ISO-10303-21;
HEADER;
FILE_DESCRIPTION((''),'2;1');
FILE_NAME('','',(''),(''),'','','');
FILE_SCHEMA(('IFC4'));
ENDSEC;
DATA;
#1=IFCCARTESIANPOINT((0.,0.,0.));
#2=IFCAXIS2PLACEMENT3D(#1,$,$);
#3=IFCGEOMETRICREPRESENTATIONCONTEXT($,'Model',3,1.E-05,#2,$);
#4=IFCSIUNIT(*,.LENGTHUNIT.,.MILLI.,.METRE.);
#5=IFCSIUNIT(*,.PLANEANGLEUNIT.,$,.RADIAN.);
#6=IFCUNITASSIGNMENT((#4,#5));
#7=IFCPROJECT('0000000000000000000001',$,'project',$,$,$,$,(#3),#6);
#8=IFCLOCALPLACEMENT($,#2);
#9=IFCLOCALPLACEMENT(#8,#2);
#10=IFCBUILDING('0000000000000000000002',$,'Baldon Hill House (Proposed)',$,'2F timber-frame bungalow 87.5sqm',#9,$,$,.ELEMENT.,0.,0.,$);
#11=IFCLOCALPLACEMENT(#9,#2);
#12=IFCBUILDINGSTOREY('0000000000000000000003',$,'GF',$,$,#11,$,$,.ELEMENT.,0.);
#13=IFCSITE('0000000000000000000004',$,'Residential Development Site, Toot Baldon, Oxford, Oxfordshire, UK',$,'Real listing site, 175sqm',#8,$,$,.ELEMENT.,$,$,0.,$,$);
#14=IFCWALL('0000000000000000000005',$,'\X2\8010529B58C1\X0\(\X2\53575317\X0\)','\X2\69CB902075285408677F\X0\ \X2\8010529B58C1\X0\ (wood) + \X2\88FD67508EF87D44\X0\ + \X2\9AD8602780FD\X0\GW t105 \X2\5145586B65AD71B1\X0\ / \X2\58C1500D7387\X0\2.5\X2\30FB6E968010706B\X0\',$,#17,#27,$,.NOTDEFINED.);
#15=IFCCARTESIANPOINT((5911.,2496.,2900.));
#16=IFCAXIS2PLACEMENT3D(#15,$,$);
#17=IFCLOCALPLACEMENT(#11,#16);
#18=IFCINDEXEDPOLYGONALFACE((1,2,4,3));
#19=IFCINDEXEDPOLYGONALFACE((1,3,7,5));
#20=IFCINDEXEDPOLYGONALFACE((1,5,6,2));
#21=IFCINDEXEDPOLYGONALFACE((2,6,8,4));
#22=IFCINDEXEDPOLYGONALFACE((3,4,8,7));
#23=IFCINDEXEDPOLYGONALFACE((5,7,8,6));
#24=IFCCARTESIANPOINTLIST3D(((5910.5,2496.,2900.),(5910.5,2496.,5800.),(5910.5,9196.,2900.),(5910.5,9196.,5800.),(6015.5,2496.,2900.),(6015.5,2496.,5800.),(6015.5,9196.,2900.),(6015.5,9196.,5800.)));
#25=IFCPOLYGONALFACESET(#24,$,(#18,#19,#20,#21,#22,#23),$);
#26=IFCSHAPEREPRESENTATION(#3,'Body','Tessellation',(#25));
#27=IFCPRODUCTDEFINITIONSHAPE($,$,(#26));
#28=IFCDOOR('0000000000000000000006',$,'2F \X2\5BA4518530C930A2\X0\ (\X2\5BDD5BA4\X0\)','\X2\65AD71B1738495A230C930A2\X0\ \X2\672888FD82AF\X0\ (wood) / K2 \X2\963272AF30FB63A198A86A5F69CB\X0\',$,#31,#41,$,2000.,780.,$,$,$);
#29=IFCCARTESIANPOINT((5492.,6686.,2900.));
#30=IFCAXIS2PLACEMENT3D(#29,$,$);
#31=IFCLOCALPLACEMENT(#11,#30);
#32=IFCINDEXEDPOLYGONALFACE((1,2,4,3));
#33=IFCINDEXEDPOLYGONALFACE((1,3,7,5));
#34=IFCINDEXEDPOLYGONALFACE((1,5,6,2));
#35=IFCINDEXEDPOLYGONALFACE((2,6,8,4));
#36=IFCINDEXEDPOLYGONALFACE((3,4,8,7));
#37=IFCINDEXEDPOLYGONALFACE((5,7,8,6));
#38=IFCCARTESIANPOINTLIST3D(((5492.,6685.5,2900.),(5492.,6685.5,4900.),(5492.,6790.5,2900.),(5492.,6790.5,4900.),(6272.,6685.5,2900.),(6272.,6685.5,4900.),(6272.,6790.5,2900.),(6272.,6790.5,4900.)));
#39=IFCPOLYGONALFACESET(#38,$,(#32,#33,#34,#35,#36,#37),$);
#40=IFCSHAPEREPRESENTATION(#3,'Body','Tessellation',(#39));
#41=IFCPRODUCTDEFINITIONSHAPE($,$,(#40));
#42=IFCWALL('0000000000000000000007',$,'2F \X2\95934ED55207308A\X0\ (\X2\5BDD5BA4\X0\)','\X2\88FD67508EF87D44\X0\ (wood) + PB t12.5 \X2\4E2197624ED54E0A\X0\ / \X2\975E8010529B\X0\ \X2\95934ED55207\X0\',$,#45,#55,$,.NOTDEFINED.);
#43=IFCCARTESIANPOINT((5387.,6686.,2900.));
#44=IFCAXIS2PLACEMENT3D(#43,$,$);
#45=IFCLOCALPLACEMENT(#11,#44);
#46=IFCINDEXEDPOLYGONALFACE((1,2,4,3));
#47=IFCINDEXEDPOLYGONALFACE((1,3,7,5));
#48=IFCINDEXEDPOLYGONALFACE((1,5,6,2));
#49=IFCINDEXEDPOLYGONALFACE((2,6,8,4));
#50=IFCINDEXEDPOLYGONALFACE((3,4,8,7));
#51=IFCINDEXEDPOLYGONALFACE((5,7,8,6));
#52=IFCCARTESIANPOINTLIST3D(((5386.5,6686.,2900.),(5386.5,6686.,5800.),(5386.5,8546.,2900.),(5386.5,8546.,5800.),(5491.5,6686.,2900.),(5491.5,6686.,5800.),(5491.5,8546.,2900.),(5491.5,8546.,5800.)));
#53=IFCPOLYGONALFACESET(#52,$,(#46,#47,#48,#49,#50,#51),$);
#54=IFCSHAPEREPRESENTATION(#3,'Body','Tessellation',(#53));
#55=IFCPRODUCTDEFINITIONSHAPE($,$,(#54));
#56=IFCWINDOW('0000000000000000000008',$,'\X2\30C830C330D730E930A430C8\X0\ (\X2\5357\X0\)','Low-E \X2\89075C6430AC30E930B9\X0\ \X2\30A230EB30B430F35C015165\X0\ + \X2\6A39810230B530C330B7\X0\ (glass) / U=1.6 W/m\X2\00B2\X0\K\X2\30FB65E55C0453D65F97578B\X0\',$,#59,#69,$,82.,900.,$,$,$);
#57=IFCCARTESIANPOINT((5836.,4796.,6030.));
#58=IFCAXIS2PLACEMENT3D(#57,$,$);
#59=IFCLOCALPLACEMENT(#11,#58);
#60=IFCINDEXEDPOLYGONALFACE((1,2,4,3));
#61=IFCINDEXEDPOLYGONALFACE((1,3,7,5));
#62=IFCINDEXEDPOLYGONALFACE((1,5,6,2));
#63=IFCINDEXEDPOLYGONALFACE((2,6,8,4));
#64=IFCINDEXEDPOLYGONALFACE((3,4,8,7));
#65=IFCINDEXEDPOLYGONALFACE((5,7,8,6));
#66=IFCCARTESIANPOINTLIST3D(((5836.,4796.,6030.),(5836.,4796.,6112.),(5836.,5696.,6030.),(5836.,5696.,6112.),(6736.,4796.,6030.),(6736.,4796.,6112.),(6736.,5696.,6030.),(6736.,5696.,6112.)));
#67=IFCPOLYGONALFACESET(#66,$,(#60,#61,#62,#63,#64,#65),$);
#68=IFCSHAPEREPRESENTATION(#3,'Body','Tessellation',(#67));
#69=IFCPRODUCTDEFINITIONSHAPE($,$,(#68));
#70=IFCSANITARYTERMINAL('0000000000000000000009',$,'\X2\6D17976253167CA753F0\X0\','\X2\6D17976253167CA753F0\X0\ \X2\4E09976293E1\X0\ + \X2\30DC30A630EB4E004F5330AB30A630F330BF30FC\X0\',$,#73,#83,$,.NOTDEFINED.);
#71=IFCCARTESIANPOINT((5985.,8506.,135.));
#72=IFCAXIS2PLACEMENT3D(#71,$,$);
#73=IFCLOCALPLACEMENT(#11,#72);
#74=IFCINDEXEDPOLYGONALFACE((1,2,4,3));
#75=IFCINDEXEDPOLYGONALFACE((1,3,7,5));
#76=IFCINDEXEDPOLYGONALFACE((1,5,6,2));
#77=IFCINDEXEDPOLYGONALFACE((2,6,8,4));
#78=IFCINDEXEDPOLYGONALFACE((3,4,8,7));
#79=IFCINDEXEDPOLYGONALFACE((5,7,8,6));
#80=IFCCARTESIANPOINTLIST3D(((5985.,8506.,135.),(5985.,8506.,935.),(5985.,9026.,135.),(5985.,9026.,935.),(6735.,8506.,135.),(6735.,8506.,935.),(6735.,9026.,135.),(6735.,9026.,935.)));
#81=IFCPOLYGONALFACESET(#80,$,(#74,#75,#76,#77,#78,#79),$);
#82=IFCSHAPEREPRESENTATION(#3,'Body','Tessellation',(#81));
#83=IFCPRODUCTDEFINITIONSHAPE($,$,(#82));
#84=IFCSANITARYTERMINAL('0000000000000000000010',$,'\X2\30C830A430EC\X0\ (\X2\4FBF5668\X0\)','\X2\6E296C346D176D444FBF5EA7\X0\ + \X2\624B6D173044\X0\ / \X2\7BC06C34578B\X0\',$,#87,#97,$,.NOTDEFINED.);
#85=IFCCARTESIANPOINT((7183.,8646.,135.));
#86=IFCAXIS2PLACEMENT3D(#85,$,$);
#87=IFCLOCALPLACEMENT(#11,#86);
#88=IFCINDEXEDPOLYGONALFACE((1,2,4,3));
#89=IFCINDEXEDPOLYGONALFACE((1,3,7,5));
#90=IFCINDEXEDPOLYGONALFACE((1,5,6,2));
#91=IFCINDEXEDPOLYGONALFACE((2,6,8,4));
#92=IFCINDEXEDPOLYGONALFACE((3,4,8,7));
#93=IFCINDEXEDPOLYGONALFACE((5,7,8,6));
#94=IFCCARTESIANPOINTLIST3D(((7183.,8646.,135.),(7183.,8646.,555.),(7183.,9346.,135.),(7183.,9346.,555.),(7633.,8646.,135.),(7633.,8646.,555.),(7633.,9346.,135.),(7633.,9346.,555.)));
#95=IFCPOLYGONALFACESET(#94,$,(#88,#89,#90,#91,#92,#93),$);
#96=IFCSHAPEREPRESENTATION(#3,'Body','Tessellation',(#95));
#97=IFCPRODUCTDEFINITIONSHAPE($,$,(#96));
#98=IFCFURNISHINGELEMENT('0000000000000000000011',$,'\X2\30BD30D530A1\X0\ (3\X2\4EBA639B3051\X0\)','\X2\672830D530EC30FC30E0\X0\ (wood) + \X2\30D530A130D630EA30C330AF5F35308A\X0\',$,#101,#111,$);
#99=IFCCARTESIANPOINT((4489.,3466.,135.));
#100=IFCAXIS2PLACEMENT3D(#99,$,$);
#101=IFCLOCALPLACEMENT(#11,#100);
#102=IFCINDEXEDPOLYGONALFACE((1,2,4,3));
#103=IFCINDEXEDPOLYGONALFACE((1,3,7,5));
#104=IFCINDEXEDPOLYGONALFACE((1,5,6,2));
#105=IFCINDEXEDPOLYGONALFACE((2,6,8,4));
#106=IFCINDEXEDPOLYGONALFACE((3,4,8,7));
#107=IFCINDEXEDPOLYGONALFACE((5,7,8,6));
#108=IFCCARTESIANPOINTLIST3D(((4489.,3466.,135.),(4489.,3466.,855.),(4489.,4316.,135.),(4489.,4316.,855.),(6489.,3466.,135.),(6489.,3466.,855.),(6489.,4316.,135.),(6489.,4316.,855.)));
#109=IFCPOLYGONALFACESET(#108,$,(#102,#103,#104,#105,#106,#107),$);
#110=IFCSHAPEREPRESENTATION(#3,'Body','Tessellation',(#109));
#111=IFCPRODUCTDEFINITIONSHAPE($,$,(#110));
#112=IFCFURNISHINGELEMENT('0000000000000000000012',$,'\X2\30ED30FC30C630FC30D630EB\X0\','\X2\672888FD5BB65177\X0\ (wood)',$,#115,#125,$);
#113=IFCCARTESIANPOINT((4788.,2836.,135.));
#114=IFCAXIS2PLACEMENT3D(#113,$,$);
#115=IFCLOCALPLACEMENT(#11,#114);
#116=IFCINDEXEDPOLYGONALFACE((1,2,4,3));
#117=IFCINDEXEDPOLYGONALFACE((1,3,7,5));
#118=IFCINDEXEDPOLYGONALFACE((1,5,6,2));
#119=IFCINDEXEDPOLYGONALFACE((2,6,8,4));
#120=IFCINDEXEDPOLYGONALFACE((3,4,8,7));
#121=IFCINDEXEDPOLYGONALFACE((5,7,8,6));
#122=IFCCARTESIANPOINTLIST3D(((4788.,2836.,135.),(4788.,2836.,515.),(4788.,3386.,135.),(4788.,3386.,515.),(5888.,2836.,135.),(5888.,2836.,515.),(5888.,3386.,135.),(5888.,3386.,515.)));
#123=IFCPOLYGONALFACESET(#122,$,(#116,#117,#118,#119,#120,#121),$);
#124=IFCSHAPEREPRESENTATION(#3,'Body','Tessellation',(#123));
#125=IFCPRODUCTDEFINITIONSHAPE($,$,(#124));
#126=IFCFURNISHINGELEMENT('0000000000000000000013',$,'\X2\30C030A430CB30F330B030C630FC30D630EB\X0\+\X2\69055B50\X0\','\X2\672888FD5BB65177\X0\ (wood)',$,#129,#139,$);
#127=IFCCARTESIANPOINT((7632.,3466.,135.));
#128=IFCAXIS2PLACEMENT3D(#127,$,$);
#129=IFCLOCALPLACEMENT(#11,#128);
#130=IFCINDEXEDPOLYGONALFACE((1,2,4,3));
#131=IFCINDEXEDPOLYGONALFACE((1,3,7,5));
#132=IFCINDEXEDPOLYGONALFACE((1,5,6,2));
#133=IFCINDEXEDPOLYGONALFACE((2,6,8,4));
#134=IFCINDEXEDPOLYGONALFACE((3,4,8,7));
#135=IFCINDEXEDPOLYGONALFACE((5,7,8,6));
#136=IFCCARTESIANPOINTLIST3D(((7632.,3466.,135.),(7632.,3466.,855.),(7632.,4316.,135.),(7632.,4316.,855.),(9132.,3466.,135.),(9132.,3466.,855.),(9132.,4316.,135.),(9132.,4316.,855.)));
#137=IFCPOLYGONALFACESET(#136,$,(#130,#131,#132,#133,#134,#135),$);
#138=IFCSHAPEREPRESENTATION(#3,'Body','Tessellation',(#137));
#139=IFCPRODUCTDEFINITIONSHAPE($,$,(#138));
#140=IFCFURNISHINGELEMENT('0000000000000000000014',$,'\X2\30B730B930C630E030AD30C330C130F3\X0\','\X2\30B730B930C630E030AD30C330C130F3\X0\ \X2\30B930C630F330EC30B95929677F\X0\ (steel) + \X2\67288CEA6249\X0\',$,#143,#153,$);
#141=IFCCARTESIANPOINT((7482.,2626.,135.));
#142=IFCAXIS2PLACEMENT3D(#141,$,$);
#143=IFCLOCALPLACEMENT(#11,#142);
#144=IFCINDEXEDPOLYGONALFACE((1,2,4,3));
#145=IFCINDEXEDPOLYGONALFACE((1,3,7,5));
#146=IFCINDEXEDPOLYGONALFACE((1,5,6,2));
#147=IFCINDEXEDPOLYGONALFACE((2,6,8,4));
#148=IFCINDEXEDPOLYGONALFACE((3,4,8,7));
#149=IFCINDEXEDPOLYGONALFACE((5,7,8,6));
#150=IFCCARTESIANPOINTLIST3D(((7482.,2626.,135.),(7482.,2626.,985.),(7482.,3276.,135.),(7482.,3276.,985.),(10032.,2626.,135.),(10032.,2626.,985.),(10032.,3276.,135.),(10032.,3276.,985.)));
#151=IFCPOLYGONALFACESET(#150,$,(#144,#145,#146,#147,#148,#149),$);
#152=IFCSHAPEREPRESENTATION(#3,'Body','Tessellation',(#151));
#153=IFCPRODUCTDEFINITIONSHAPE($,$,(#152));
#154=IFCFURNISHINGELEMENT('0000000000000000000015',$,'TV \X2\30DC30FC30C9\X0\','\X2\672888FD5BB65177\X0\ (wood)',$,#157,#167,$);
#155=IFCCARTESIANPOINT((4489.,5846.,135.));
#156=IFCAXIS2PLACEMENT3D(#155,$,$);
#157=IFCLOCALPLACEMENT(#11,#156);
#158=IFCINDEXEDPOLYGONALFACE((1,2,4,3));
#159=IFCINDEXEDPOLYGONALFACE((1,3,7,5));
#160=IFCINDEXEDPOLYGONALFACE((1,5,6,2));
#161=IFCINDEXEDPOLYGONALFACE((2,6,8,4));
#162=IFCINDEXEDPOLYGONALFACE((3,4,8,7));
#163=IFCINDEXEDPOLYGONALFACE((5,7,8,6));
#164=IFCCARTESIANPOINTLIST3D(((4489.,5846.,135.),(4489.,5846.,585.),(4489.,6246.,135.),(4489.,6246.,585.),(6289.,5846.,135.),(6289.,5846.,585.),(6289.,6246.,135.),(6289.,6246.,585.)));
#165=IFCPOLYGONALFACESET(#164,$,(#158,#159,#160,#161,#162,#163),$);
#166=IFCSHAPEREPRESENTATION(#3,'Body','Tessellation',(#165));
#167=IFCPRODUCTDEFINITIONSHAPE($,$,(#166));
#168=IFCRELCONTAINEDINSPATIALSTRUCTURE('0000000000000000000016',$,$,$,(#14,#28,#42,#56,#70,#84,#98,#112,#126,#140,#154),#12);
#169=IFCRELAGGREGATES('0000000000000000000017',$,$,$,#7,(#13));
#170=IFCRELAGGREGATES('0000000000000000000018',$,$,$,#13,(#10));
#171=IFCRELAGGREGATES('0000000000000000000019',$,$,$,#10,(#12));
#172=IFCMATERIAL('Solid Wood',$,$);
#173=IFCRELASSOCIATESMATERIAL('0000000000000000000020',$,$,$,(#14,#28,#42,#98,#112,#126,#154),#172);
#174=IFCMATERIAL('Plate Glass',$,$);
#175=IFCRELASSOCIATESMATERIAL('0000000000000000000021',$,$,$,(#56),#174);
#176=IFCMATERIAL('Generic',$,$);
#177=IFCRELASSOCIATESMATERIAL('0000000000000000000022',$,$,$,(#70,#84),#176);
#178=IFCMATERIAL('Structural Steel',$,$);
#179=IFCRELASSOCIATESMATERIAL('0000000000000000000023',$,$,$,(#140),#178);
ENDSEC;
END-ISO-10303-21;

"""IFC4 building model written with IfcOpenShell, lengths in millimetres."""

from ifc_helpers import new_model, si_unit, frame, frame_2d, origin, place, context, project, spatial, rectangle, extrude, material, element, fill, save


model = new_model("IFC4")

# Units and contexts
model_context = context("Model", 3, precision=1e-05, world=origin())
ifc_project = project(units=[si_unit("LENGTHUNIT", "METRE", prefix="MILLI"), si_unit("PLANEANGLEUNIT", "RADIAN")], contexts=[model_context])

# Site, building, storey
site_placement = place(None, origin())
site = spatial("IfcSite", under=ifc_project, at=site_placement, Name="Residential Development Site, Toot Baldon, Oxford, Oxfordshire, UK", ObjectType="Real listing site, 175sqm", CompositionType="ELEMENT", RefElevation=0.0)
building_placement = place(site_placement, origin())
building = spatial("IfcBuilding", under=site, at=building_placement, Name="Baldon Hill House (Proposed)", ObjectType="2F timber-frame bungalow 87.5sqm", CompositionType="ELEMENT", ElevationOfRefHeight=0.0, ElevationOfTerrain=0.0)
storey_placement = place(building_placement, origin())
storey = spatial("IfcBuildingStorey", under=building, at=storey_placement, Name="GF", CompositionType="ELEMENT", Elevation=0.0)

# Shared definitions
ifc_material_1 = material(Name="Solid Wood")

# Wall, opening, door
wall_1_placement = place(storey_placement, frame((5911.0, 2496.0, 2900.0)))
wall_1 = element("IfcWall", 1, at=wall_1_placement, inside=storey, material=ifc_material_1, Name="耐力壁(南北)", Description="構造用合板 耐力壁 (wood) + 製材軸組 + 高性能GW t105 充填断熱 / 壁倍率2.5・準耐火", PredefinedType="NOTDEFINED", context=model_context, shape_type="SweptSolid", body=[
    extrude(rectangle(XDim=105.0, YDim=6700.0, at=frame_2d((52.0, 3350.0))), frame((5911.0, 2496.0, 2900.0)), (0.0, 0.0, 1.0), 2900.0),
])
opening_1_placement = place(storey_placement, frame((5492.0, 6686.0, 2900.0)))
opening_1 = element("IfcOpeningElement", 2, at=opening_1_placement, cuts=wall_1, PredefinedType="NOTDEFINED", context=model_context, shape_type="SweptSolid", body=[
    extrude(rectangle(XDim=780.0, YDim=105.0, at=frame_2d((390.0, 52.0))), frame((5492.0, 6686.0, 2900.0)), (0.0, 0.0, 1.0), 2000.0),
])
door_1_placement = place(storey_placement, frame((5492.0, 6686.0, 2900.0)))
door_1 = element("IfcDoor", 3, at=door_1_placement, inside=storey, material=ifc_material_1, Name="2F 室内ドア (寝室)", Description="断熱玄関ドア 木製芯 (wood) / K2 防犯・採風機構", OverallHeight=2000.0, OverallWidth=780.0, context=model_context, shape_type="SweptSolid", body=[
    extrude(rectangle(XDim=780.0, YDim=105.0, at=frame_2d((390.0, 52.0))), frame((5492.0, 6686.0, 2900.0)), (0.0, 0.0, 1.0), 2000.0),
])
fill(opening_1, door_1)

# Wall
wall_2_placement = place(storey_placement, frame((5387.0, 6686.0, 2900.0)))
element("IfcWall", 4, at=wall_2_placement, inside=storey, material=ifc_material_1, Name="2F 間仕切り (寝室)", Description="製材軸組 (wood) + PB t12.5 両面仕上 / 非耐力 間仕切", PredefinedType="NOTDEFINED", context=model_context, shape_type="SweptSolid", body=[
    extrude(rectangle(XDim=105.0, YDim=1860.0, at=frame_2d((52.0, 930.0))), frame((5387.0, 6686.0, 2900.0)), (0.0, 0.0, 1.0), 2900.0),
])

# Window
ifc_material_2 = material(Name="Plate Glass")
window_placement = place(storey_placement, frame((5836.0, 4796.0, 6030.0)))
element("IfcWindow", 5, at=window_placement, inside=storey, material=ifc_material_2, Name="トップライト (南)", Description="Low-E 複層ガラス アルゴン封入 + 樹脂サッシ (glass) / U=1.6 W/m²K・日射取得型", OverallHeight=82.0, OverallWidth=900.0, context=model_context, shape_type="SweptSolid", body=[
    extrude(rectangle(XDim=900.0, YDim=900.0, at=frame_2d((450.0, 450.0))), frame((5836.0, 4796.0, 6030.0)), (0.0, 0.0, 1.0), 82.0),
])

# Sanitary terminals
ifc_material_3 = material(Name="Generic")
sanitary_terminal_1_placement = place(storey_placement, frame((5985.0, 8506.0, 135.0)))
element("IfcSanitaryTerminal", 6, at=sanitary_terminal_1_placement, inside=storey, material=ifc_material_3, Name="洗面化粧台", Description="洗面化粧台 三面鏡 + ボウル一体カウンター", PredefinedType="NOTDEFINED", context=model_context, shape_type="SweptSolid", body=[
    extrude(rectangle(XDim=750.0, YDim=520.0, at=frame_2d((375.0, 260.0))), frame((5985.0, 8506.0, 135.0)), (0.0, 0.0, 1.0), 800.0),
])
sanitary_terminal_2_placement = place(storey_placement, frame((7183.0, 8646.0, 135.0)))
element("IfcSanitaryTerminal", 7, at=sanitary_terminal_2_placement, inside=storey, material=ifc_material_3, Name="トイレ (便器)", Description="温水洗浄便座 + 手洗い / 節水型", PredefinedType="NOTDEFINED", context=model_context, shape_type="SweptSolid", body=[
    extrude(rectangle(XDim=450.0, YDim=700.0, at=frame_2d((225.0, 350.0))), frame((7183.0, 8646.0, 135.0)), (0.0, 0.0, 1.0), 420.0),
])

# Furnishing elements
furnishing_1_placement = place(storey_placement, frame((4489.0, 3466.0, 135.0)))
element("IfcFurnishingElement", 8, at=furnishing_1_placement, inside=storey, material=ifc_material_1, Name="ソファ (3人掛け)", Description="木フレーム (wood) + ファブリック張り", context=model_context, shape_type="SweptSolid", body=[
    extrude(rectangle(XDim=2000.0, YDim=850.0, at=frame_2d((1000.0, 425.0))), frame((4489.0, 3466.0, 135.0)), (0.0, 0.0, 1.0), 720.0),
])
furnishing_2_placement = place(storey_placement, frame((4788.0, 2836.0, 135.0)))
element("IfcFurnishingElement", 9, at=furnishing_2_placement, inside=storey, material=ifc_material_1, Name="ローテーブル", Description="木製家具 (wood)", context=model_context, shape_type="SweptSolid", body=[
    extrude(rectangle(XDim=1100.0, YDim=550.0, at=frame_2d((550.0, 275.0))), frame((4788.0, 2836.0, 135.0)), (0.0, 0.0, 1.0), 380.0),
])
furnishing_3_placement = place(storey_placement, frame((7632.0, 3466.0, 135.0)))
element("IfcFurnishingElement", 10, at=furnishing_3_placement, inside=storey, material=ifc_material_1, Name="ダイニングテーブル+椅子", Description="木製家具 (wood)", context=model_context, shape_type="SweptSolid", body=[
    extrude(rectangle(XDim=1500.0, YDim=850.0, at=frame_2d((750.0, 425.0))), frame((7632.0, 3466.0, 135.0)), (0.0, 0.0, 1.0), 720.0),
])
ifc_material_4 = material(Name="Structural Steel")
furnishing_4_placement = place(storey_placement, frame((7482.0, 2626.0, 135.0)))
element("IfcFurnishingElement", 11, at=furnishing_4_placement, inside=storey, material=ifc_material_4, Name="システムキッチン", Description="システムキッチン ステンレス天板 (steel) + 木質扉", context=model_context, shape_type="SweptSolid", body=[
    extrude(rectangle(XDim=2550.0, YDim=650.0, at=frame_2d((1275.0, 325.0))), frame((7482.0, 2626.0, 135.0)), (0.0, 0.0, 1.0), 850.0),
])
furnishing_5_placement = place(storey_placement, frame((4489.0, 5846.0, 135.0)))
element("IfcFurnishingElement", 12, at=furnishing_5_placement, inside=storey, material=ifc_material_1, Name="TV ボード", Description="木製家具 (wood)", context=model_context, shape_type="SweptSolid", body=[
    extrude(rectangle(XDim=1800.0, YDim=400.0, at=frame_2d((900.0, 200.0))), frame((4489.0, 5846.0, 135.0)), (0.0, 0.0, 1.0), 450.0),
])

save(model, "model.ifc")
